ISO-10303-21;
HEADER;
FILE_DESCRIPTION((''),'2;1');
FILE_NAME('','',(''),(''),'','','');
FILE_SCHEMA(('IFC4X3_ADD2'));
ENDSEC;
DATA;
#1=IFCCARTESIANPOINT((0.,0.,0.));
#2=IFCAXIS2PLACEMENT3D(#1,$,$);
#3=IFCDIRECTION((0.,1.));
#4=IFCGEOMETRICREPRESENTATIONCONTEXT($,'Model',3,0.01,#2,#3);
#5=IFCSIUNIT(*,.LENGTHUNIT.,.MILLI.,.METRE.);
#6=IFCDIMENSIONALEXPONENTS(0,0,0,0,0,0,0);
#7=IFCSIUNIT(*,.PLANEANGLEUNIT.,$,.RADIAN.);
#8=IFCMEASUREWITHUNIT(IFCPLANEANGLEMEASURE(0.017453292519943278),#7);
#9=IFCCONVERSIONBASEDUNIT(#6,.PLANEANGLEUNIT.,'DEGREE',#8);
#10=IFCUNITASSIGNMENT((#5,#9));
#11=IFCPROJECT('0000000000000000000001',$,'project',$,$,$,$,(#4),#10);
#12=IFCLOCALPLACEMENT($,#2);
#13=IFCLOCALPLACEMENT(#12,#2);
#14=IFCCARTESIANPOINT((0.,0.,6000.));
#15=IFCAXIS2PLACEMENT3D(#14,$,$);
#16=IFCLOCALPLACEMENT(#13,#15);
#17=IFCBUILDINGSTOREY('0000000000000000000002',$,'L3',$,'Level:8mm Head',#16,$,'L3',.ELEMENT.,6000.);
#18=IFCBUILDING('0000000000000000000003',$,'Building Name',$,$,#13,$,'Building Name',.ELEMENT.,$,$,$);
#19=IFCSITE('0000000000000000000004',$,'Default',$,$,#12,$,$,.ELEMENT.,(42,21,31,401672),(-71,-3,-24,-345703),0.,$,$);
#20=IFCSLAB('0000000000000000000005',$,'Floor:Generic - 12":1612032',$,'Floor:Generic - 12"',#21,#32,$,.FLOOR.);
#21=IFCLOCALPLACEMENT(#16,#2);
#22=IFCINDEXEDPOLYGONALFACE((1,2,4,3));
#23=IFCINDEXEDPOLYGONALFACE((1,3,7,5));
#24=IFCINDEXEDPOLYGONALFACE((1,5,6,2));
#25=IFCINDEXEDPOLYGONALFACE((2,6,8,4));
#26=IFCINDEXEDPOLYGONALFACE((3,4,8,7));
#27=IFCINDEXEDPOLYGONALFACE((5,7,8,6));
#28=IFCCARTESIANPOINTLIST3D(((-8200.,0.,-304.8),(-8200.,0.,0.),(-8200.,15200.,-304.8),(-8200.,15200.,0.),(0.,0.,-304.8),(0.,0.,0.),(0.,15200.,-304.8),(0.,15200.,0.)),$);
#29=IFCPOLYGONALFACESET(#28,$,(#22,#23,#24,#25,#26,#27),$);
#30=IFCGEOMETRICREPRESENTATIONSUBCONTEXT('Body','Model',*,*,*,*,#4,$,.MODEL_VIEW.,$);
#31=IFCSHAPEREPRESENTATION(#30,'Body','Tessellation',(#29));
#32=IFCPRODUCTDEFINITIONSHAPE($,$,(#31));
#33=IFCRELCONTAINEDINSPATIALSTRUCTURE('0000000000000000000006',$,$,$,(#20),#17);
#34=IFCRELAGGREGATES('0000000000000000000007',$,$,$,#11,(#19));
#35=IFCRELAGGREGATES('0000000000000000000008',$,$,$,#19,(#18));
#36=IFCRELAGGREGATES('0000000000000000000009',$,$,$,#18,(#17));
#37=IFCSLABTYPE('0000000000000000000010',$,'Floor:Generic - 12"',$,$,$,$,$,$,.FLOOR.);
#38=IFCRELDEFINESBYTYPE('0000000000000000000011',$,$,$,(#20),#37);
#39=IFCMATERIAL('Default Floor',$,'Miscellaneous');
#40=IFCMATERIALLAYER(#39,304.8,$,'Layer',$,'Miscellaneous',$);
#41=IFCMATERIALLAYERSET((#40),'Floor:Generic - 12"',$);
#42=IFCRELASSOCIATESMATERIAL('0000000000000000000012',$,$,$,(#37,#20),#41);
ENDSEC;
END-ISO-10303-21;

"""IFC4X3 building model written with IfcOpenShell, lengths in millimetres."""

from ifc_helpers import new_model, entity, si_unit, converted_unit, direction, frame, frame_2d, origin, place, context, subcontext, project, spatial, rectangle, extrude, material, layer, layer_set, layer_usage, type_object, element, save


model = new_model("IFC4X3")

# Units and contexts
model_context = context("Model", 3, precision=0.01, world=origin(), true_north=direction((0.0, 1.0)))
body_context = subcontext(model_context, "Body", "Model", "MODEL_VIEW")
ifc_project = project(units=[si_unit("LENGTHUNIT", "METRE", prefix="MILLI"), converted_unit("PLANEANGLEUNIT", "DEGREE", entity("IfcPlaneAngleMeasure", 0.017453292519943278), si_unit("PLANEANGLEUNIT", "RADIAN"), dimensions=[0, 0, 0, 0, 0, 0, 0])], contexts=[model_context])

# Site, building, storey
site_placement = place(None, origin())
site = spatial("IfcSite", under=ifc_project, at=site_placement, Name="Default", CompositionType="ELEMENT", RefLatitude=(42, 21, 31, 401672), RefLongitude=(-71, -3, -24, -345703), RefElevation=0.0)
building_placement = place(site_placement, origin())
building = spatial("IfcBuilding", under=site, at=building_placement, Name="Building Name", LongName="Building Name", CompositionType="ELEMENT")
storey_placement = place(building_placement, frame((0.0, 0.0, 6000.0)))
storey = spatial("IfcBuildingStorey", under=building, at=storey_placement, Name="L3", ObjectType="Level:8mm Head", LongName="L3", CompositionType="ELEMENT", Elevation=6000.0)

# Slab
ifc_material = material(Name="Default Floor", Category="Miscellaneous")
ifc_layer = layer(ifc_material, 304.8, Name="Layer", Category="Miscellaneous")
ifc_layer_set = layer_set([ifc_layer], Name="Floor:Generic - 12\"")
ifc_layer_usage = layer_usage(ifc_layer_set, "AXIS3", "POSITIVE", 0.0)
slab_type = type_object("IfcSlabType", Name="Floor:Generic - 12\"", PredefinedType="FLOOR", material=ifc_layer_set)
slab_placement = place(storey_placement, origin())
element("IfcSlab", 1, at=slab_placement, inside=storey, type_object=slab_type, material=ifc_layer_usage, Name="Floor:Generic - 12\":1612032", ObjectType="Floor:Generic - 12\"", PredefinedType="FLOOR", context=body_context, shape_type="SweptSolid", body=[
    extrude(rectangle(XDim=15200.0, YDim=8200.0, at=frame_2d((0.0, 0.0), x_axis=(1.0, 0.0))), frame((-4100.0, 7600.0, 0.0), z_axis=(0.0, 0.0, -1.0), x_axis=(0.0, 1.0, 0.0)), (0.0, 0.0, 1.0), 304.8),
])

save(model, "model.ifc")
